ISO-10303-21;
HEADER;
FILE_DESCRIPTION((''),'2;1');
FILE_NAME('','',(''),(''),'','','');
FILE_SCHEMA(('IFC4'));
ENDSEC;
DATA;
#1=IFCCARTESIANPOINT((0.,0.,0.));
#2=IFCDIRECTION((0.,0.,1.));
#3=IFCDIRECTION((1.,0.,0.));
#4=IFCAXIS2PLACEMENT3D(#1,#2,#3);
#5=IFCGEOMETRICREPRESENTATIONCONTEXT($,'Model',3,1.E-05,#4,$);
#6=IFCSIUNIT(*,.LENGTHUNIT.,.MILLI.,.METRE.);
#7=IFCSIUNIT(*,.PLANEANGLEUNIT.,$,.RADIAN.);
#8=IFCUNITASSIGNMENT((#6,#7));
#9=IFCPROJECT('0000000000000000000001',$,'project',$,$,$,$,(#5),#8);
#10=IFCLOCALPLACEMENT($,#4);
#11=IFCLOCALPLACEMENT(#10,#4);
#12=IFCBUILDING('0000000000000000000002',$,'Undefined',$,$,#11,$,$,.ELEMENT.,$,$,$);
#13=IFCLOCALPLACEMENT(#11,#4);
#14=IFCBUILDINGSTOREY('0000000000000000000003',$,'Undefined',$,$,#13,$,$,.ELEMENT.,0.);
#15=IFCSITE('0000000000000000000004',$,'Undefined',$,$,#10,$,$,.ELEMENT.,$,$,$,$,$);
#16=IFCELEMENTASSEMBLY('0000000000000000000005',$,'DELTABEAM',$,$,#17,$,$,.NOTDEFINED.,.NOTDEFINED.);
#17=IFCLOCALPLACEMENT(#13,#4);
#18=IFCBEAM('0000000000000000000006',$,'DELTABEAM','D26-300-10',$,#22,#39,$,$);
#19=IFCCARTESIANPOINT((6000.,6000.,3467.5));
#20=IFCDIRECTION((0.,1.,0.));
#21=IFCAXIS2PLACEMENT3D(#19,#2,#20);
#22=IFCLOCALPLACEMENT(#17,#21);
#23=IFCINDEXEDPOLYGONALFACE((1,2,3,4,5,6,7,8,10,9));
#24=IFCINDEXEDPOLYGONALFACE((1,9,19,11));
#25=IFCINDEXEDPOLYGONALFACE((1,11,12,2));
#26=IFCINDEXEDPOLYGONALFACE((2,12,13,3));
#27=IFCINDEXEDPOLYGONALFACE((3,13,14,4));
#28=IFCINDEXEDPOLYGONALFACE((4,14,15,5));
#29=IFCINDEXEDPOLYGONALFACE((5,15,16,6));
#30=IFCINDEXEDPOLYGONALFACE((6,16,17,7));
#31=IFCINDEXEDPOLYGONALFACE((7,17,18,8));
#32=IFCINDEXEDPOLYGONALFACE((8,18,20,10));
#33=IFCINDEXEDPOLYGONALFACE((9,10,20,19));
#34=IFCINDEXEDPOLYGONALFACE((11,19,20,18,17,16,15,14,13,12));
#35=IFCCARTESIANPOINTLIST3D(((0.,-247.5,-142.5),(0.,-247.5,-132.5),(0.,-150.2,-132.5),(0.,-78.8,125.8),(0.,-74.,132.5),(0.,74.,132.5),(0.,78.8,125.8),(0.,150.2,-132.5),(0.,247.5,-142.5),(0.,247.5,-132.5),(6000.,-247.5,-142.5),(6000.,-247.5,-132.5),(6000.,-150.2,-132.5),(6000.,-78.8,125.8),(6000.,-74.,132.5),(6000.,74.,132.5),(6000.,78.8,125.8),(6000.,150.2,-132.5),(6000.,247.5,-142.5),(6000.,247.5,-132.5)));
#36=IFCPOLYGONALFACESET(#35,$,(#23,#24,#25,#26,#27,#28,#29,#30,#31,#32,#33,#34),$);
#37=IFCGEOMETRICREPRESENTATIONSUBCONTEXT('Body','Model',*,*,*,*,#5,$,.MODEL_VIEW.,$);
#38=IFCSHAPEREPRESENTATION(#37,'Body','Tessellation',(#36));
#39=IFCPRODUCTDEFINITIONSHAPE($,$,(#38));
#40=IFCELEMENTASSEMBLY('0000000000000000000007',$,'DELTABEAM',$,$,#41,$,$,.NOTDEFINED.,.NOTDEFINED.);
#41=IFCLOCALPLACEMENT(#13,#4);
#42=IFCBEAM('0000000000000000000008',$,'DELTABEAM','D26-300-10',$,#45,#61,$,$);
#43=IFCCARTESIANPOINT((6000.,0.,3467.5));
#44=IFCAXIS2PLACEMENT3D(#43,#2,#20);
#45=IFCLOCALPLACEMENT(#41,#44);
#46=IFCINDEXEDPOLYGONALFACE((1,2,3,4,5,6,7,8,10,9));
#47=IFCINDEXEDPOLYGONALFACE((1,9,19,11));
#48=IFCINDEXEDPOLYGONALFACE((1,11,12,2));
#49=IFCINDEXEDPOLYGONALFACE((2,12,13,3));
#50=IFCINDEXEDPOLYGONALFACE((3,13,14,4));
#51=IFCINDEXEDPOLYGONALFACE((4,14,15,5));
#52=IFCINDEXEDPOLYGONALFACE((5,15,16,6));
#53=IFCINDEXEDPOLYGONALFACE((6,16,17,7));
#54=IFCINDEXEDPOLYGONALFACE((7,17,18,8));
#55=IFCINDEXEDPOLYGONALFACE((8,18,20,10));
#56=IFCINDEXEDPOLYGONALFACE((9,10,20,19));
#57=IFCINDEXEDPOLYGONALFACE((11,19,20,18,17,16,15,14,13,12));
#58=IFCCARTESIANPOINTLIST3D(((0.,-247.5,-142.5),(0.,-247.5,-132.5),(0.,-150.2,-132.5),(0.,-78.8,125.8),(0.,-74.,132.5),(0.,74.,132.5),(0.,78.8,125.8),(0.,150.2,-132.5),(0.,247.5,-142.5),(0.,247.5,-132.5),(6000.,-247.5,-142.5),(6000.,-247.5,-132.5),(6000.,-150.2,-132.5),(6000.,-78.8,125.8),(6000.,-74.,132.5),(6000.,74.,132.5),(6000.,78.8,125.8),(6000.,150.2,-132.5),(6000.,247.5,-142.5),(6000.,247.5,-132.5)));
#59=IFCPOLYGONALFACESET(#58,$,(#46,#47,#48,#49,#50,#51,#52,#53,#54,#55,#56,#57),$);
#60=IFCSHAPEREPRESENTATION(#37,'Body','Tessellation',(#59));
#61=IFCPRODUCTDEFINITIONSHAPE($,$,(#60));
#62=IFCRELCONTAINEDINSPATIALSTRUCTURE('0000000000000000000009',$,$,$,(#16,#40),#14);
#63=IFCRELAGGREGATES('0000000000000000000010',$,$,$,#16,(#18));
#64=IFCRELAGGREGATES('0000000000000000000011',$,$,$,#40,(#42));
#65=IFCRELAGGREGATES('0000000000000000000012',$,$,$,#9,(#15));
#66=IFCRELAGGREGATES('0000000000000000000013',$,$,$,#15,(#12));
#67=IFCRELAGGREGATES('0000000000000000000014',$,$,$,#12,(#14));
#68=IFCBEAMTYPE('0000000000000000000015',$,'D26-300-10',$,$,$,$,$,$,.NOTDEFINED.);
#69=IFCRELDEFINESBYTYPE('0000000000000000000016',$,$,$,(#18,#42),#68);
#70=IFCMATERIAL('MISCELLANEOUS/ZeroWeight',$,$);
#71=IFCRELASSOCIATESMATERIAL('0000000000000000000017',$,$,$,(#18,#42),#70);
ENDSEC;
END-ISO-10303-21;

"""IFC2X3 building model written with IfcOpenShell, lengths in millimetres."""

from ifc_helpers import new_model, si_unit, frame, origin_with_axes, place, context, subcontext, project, spatial, polyline, outline, extrude, material, type_object, element, aggregate, save


model = new_model("IFC2X3")

# Units and contexts
model_context = context("Model", 3, precision=1e-05, world=origin_with_axes())
body_context = subcontext(model_context, "Body", "Model", "MODEL_VIEW")
ifc_project = project(units=[si_unit("LENGTHUNIT", "METRE", prefix="MILLI"), si_unit("PLANEANGLEUNIT", "RADIAN")], contexts=[model_context])

# Site, building, storey
site_placement = place(None, origin_with_axes())
site = spatial("IfcSite", under=ifc_project, at=site_placement, Name="Undefined", CompositionType="ELEMENT")
building_placement = place(site_placement, origin_with_axes())
building = spatial("IfcBuilding", under=site, at=building_placement, Name="Undefined", CompositionType="ELEMENT")
storey_placement = place(building_placement, origin_with_axes())
storey = spatial("IfcBuildingStorey", under=building, at=storey_placement, Name="Undefined", CompositionType="ELEMENT", Elevation=0.0)

# Element assemblies, beams
ifc_material_1 = material(Name="MISCELLANEOUS/ZeroWeight")
assembly_1_placement = place(storey_placement, origin_with_axes())
assembly_1 = element("IfcElementAssembly", 1, at=assembly_1_placement, inside=storey, Name="DELTABEAM", AssemblyPlace="NOTDEFINED", PredefinedType="NOTDEFINED")
beam_type_1 = type_object("IfcBeamType", Name="D26-300-10", PredefinedType="NOTDEFINED")
beam_1_placement = place(assembly_1_placement, frame((6000.0, 6000.0, 3467.5), z_axis=(0.0, 0.0, 1.0), x_axis=(0.0, 1.0, 0.0)))
beam_1 = element("IfcBeam", 2, at=beam_1_placement, type_object=beam_type_1, material=ifc_material_1, Name="DELTABEAM", Description="D26-300-10", context=body_context, shape_type="SweptSolid", body=[
    extrude(outline(polyline([(-75.1, 120.5), (-145.0, -132.5), (247.5, -132.5), (247.5, -142.5), (-247.5, -142.5), (-247.5, -132.5), (-150.2, -132.5), (-78.8, 125.8), (-74.0, 132.5), (74.0, 132.5), (78.8, 125.8), (150.2, -132.5), (145.0, -132.5), (75.1, 120.5), (-75.1, 120.5)])), frame((6000.0, 0.0, 0.0), z_axis=(-1.0, 0.0, 0.0), x_axis=(0.0, -1.0, 0.0)), (0.0, 0.0, 1.0), 6000.0),
])
aggregate(assembly_1, [beam_1])
assembly_2_placement = place(storey_placement, origin_with_axes())
assembly_2 = element("IfcElementAssembly", 3, at=assembly_2_placement, inside=storey, Name="DELTABEAM", AssemblyPlace="NOTDEFINED", PredefinedType="NOTDEFINED")
beam_2_placement = place(assembly_2_placement, frame((6000.0, 0.0, 3467.5), z_axis=(0.0, 0.0, 1.0), x_axis=(0.0, 1.0, 0.0)))
beam_2 = element("IfcBeam", 4, at=beam_2_placement, type_object=beam_type_1, material=ifc_material_1, Name="DELTABEAM", Description="D26-300-10", context=body_context, shape_type="SweptSolid", body=[
    extrude(outline(polyline([(-75.1, 120.5), (-145.0, -132.5), (247.5, -132.5), (247.5, -142.5), (-247.5, -142.5), (-247.5, -132.5), (-150.2, -132.5), (-78.8, 125.8), (-74.0, 132.5), (74.0, 132.5), (78.8, 125.8), (150.2, -132.5), (145.0, -132.5), (75.1, 120.5), (-75.1, 120.5)])), frame((6000.0, 0.0, 0.0), z_axis=(-1.0, 0.0, 0.0), x_axis=(0.0, -1.0, 0.0)), (0.0, 0.0, 1.0), 6000.0),
])
aggregate(assembly_2, [beam_2])

save(model, "model.ifc")
